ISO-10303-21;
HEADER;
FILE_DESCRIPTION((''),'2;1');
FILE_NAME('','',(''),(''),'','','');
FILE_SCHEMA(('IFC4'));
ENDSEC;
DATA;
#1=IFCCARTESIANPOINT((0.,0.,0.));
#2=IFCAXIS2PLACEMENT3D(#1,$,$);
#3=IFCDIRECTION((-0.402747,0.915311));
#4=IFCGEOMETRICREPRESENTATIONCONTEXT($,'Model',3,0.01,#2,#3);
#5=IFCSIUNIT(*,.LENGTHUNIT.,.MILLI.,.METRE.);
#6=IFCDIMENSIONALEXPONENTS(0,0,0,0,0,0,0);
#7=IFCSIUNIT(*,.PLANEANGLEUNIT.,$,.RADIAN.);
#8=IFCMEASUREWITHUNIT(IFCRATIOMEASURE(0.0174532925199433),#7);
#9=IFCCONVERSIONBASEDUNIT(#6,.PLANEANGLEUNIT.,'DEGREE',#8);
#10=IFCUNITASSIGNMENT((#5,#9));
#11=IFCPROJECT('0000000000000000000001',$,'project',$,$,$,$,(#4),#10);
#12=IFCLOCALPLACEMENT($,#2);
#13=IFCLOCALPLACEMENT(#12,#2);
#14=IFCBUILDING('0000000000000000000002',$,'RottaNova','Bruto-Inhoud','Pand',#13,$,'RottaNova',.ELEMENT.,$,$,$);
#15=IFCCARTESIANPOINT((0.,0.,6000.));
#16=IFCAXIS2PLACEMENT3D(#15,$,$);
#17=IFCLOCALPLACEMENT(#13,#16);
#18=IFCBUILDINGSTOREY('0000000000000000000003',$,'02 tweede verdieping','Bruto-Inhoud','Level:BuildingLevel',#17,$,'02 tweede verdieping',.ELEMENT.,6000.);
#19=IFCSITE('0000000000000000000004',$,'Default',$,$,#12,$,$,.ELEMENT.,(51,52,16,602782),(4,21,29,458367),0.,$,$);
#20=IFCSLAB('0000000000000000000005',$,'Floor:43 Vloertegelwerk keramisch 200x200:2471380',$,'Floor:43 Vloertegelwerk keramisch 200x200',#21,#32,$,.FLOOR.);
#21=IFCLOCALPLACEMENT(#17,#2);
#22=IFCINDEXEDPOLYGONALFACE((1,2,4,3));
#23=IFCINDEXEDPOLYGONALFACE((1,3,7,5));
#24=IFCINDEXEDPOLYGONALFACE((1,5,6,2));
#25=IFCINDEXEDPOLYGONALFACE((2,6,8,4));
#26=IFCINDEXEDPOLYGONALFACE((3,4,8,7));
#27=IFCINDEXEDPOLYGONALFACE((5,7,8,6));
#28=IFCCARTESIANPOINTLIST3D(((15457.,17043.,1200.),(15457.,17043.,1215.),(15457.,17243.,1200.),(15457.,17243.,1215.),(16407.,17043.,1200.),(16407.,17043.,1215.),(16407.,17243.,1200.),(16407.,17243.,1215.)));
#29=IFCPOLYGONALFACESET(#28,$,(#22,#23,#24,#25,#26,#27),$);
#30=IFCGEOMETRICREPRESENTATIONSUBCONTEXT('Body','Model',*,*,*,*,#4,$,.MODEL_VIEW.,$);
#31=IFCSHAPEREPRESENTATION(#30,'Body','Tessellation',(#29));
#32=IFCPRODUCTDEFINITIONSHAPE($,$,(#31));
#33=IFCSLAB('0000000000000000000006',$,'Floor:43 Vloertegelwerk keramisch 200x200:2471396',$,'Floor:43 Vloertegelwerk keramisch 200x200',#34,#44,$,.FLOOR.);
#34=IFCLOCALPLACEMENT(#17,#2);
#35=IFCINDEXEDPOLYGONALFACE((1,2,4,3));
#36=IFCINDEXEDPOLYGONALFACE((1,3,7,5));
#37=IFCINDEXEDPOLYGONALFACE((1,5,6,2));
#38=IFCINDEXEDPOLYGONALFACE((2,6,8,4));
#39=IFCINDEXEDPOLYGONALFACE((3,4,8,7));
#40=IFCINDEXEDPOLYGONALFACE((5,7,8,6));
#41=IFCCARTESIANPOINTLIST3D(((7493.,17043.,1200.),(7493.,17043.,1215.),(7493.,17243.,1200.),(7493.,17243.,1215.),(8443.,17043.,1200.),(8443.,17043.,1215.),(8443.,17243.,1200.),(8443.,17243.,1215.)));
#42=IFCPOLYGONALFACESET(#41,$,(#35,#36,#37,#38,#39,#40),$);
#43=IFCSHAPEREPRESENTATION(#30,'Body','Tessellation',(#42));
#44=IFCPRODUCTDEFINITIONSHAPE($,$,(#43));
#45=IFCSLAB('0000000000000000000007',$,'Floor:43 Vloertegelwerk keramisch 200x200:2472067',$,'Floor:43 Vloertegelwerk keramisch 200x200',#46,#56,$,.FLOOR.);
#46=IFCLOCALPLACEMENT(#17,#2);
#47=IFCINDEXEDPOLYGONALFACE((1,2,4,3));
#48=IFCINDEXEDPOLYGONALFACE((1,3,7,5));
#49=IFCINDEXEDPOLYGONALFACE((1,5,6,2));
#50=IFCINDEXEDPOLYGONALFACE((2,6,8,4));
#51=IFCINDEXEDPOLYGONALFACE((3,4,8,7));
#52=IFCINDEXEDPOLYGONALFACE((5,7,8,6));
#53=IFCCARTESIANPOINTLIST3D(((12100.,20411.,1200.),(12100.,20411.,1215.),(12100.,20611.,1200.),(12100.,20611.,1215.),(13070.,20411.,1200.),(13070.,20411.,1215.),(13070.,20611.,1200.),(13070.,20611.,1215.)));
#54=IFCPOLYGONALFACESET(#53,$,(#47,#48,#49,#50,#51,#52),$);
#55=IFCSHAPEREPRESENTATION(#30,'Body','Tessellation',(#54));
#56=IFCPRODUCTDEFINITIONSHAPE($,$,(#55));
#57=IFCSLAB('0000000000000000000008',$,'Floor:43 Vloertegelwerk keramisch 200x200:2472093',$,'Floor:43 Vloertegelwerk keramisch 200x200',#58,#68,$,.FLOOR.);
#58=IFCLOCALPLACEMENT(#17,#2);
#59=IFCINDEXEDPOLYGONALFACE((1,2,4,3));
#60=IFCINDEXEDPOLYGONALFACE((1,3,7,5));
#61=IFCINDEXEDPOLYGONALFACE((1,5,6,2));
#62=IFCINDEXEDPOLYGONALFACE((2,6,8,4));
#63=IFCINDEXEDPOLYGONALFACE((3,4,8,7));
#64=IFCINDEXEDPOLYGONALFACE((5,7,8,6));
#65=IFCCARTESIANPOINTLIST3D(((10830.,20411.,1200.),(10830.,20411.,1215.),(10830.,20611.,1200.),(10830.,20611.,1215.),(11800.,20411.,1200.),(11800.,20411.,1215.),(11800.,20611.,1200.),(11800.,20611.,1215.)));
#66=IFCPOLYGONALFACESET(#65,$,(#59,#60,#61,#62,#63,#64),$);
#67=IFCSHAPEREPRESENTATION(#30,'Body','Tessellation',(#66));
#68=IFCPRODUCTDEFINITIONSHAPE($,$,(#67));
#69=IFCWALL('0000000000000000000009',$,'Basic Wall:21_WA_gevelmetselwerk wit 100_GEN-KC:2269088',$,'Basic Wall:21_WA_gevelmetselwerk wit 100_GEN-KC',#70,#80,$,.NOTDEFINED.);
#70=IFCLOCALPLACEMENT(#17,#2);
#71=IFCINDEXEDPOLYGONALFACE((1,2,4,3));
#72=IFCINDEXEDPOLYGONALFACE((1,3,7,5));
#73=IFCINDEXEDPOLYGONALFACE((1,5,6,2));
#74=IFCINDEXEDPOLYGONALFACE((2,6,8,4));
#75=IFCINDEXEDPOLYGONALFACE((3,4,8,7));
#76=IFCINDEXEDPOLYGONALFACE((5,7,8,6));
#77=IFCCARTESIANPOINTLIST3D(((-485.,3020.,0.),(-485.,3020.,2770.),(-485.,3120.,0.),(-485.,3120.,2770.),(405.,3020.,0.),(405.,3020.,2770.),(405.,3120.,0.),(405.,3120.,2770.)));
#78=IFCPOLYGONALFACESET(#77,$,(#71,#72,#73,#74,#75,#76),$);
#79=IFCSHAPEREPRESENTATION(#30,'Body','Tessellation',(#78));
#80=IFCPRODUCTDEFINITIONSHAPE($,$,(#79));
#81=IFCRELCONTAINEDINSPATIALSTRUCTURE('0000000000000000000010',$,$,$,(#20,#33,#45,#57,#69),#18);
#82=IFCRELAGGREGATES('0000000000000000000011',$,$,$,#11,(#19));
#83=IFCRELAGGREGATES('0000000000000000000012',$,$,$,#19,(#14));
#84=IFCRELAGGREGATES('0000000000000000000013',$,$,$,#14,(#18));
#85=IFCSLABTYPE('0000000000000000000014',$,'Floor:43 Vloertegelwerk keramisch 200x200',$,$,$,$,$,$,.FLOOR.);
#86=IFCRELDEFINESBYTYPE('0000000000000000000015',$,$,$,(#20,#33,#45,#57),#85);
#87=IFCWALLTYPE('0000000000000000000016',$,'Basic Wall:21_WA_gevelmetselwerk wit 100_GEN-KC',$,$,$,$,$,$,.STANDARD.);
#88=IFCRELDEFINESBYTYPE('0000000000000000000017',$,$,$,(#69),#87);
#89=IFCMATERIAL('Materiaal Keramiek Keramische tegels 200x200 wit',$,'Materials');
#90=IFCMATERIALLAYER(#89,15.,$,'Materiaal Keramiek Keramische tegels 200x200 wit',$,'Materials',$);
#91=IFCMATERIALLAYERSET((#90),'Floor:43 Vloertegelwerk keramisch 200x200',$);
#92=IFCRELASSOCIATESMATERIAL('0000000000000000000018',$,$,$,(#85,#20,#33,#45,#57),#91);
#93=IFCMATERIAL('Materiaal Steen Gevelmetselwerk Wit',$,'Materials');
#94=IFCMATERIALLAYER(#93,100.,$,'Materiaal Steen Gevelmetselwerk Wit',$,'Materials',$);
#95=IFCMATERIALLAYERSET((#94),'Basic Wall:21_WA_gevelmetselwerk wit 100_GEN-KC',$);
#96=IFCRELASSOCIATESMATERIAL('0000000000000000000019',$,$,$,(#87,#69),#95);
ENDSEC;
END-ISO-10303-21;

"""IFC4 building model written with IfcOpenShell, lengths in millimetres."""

from ifc_helpers import new_model, entity, si_unit, converted_unit, direction, frame, frame_2d, origin, origin_2d_with_axis, place, context, subcontext, project, spatial, rectangle, extrude, material, layer, layer_set, layer_usage, type_object, element, save


model = new_model("IFC4")

# Units and contexts
model_context = context("Model", 3, precision=0.01, world=origin(), true_north=direction((-0.402747, 0.915311)))
body_context = subcontext(model_context, "Body", "Model", "MODEL_VIEW")
ifc_project = project(units=[si_unit("LENGTHUNIT", "METRE", prefix="MILLI"), converted_unit("PLANEANGLEUNIT", "DEGREE", entity("IfcRatioMeasure", 0.0174532925199433), si_unit("PLANEANGLEUNIT", "RADIAN"), dimensions=[0, 0, 0, 0, 0, 0, 0])], contexts=[model_context])

# Site, building, storey
site_placement = place(None, origin())
site = spatial("IfcSite", under=ifc_project, at=site_placement, Name="Default", CompositionType="ELEMENT", RefLatitude=(51, 52, 16, 602782), RefLongitude=(4, 21, 29, 458367), RefElevation=0.0)
building_placement = place(site_placement, origin())
building = spatial("IfcBuilding", under=site, at=building_placement, Name="RottaNova", Description="Bruto-Inhoud", ObjectType="Pand", LongName="RottaNova", CompositionType="ELEMENT")
storey_placement = place(building_placement, frame((0.0, 0.0, 6000.0)))
storey = spatial("IfcBuildingStorey", under=building, at=storey_placement, Name="02 tweede verdieping", Description="Bruto-Inhoud", ObjectType="Level:BuildingLevel", LongName="02 tweede verdieping", CompositionType="ELEMENT", Elevation=6000.0)

# Slabs
ifc_material_1 = material(Name="Materiaal Keramiek Keramische tegels 200x200 wit", Category="Materials")
ifc_layer_1 = layer(ifc_material_1, 15.0, Name="Materiaal Keramiek Keramische tegels 200x200 wit", Category="Materials")
ifc_layer_set_1 = layer_set([ifc_layer_1], Name="Floor:43 Vloertegelwerk keramisch 200x200")
ifc_layer_usage_1 = layer_usage(ifc_layer_set_1, "AXIS3", "POSITIVE", 0.0)
slab_type_1 = type_object("IfcSlabType", Name="Floor:43 Vloertegelwerk keramisch 200x200", PredefinedType="FLOOR", material=ifc_layer_set_1)
slab_1_placement = place(storey_placement, origin())
element("IfcSlab", 1, at=slab_1_placement, inside=storey, type_object=slab_type_1, material=ifc_layer_usage_1, Name="Floor:43 Vloertegelwerk keramisch 200x200:2471380", ObjectType="Floor:43 Vloertegelwerk keramisch 200x200", PredefinedType="FLOOR", context=body_context, shape_type="SweptSolid", body=[
    extrude(rectangle(XDim=200.0, YDim=950.0, at=frame_2d((0.0, 0.0), x_axis=(1.0, 0.0))), frame((15932.0, 17143.0, 1215.0), z_axis=(0.0, 0.0, -1.0), x_axis=(0.0, 1.0, 0.0)), (0.0, 0.0, 1.0), 15.0),
])
slab_2_placement = place(storey_placement, origin())
element("IfcSlab", 2, at=slab_2_placement, inside=storey, type_object=slab_type_1, material=ifc_layer_usage_1, Name="Floor:43 Vloertegelwerk keramisch 200x200:2471396", ObjectType="Floor:43 Vloertegelwerk keramisch 200x200", PredefinedType="FLOOR", context=body_context, shape_type="SweptSolid", body=[
    extrude(rectangle(XDim=200.0, YDim=950.0, at=origin_2d_with_axis()), frame((7968.0, 17143.0, 1215.0), z_axis=(0.0, 0.0, -1.0), x_axis=(0.0, 1.0, 0.0)), (0.0, 0.0, 1.0), 15.0),
])
slab_3_placement = place(storey_placement, origin())
element("IfcSlab", 3, at=slab_3_placement, inside=storey, type_object=slab_type_1, material=ifc_layer_usage_1, Name="Floor:43 Vloertegelwerk keramisch 200x200:2472067", ObjectType="Floor:43 Vloertegelwerk keramisch 200x200", PredefinedType="FLOOR", context=body_context, shape_type="SweptSolid", body=[
    extrude(rectangle(XDim=200.0, YDim=970.0, at=origin_2d_with_axis()), frame((12585.0, 20511.0, 1215.0), z_axis=(0.0, 0.0, -1.0), x_axis=(0.0, 1.0, 0.0)), (0.0, 0.0, 1.0), 15.0),
])
slab_4_placement = place(storey_placement, origin())
element("IfcSlab", 4, at=slab_4_placement, inside=storey, type_object=slab_type_1, material=ifc_layer_usage_1, Name="Floor:43 Vloertegelwerk keramisch 200x200:2472093", ObjectType="Floor:43 Vloertegelwerk keramisch 200x200", PredefinedType="FLOOR", context=body_context, shape_type="SweptSolid", body=[
    extrude(rectangle(XDim=200.0, YDim=970.0, at=origin_2d_with_axis()), frame((11315.0, 20511.0, 1215.0), z_axis=(0.0, 0.0, -1.0), x_axis=(0.0, 1.0, 0.0)), (0.0, 0.0, 1.0), 15.0),
])

# Wall
ifc_material_2 = material(Name="Materiaal Steen Gevelmetselwerk Wit", Category="Materials")
ifc_layer_2 = layer(ifc_material_2, 100.0, Name="Materiaal Steen Gevelmetselwerk Wit", Category="Materials")
ifc_layer_set_2 = layer_set([ifc_layer_2], Name="Basic Wall:21_WA_gevelmetselwerk wit 100_GEN-KC")
wall_type = type_object("IfcWallType", Name="Basic Wall:21_WA_gevelmetselwerk wit 100_GEN-KC", PredefinedType="STANDARD", material=ifc_layer_set_2)
wall_placement = place(storey_placement, frame((-485.0, 3070.0, 0.0)))
element("IfcWall", 5, at=wall_placement, inside=storey, type_object=wall_type, material=ifc_layer_set_2, Name="Basic Wall:21_WA_gevelmetselwerk wit 100_GEN-KC:2269088", ObjectType="Basic Wall:21_WA_gevelmetselwerk wit 100_GEN-KC", PredefinedType="NOTDEFINED", context=body_context, shape_type="SweptSolid", body=[
    extrude(rectangle(XDim=890.0, YDim=100.0, at=frame_2d((445.0, 0.0), x_axis=(-1.0, 0.0))), origin(), (0.0, 0.0, 1.0), 2770.0),
])

save(model, "model.ifc")
